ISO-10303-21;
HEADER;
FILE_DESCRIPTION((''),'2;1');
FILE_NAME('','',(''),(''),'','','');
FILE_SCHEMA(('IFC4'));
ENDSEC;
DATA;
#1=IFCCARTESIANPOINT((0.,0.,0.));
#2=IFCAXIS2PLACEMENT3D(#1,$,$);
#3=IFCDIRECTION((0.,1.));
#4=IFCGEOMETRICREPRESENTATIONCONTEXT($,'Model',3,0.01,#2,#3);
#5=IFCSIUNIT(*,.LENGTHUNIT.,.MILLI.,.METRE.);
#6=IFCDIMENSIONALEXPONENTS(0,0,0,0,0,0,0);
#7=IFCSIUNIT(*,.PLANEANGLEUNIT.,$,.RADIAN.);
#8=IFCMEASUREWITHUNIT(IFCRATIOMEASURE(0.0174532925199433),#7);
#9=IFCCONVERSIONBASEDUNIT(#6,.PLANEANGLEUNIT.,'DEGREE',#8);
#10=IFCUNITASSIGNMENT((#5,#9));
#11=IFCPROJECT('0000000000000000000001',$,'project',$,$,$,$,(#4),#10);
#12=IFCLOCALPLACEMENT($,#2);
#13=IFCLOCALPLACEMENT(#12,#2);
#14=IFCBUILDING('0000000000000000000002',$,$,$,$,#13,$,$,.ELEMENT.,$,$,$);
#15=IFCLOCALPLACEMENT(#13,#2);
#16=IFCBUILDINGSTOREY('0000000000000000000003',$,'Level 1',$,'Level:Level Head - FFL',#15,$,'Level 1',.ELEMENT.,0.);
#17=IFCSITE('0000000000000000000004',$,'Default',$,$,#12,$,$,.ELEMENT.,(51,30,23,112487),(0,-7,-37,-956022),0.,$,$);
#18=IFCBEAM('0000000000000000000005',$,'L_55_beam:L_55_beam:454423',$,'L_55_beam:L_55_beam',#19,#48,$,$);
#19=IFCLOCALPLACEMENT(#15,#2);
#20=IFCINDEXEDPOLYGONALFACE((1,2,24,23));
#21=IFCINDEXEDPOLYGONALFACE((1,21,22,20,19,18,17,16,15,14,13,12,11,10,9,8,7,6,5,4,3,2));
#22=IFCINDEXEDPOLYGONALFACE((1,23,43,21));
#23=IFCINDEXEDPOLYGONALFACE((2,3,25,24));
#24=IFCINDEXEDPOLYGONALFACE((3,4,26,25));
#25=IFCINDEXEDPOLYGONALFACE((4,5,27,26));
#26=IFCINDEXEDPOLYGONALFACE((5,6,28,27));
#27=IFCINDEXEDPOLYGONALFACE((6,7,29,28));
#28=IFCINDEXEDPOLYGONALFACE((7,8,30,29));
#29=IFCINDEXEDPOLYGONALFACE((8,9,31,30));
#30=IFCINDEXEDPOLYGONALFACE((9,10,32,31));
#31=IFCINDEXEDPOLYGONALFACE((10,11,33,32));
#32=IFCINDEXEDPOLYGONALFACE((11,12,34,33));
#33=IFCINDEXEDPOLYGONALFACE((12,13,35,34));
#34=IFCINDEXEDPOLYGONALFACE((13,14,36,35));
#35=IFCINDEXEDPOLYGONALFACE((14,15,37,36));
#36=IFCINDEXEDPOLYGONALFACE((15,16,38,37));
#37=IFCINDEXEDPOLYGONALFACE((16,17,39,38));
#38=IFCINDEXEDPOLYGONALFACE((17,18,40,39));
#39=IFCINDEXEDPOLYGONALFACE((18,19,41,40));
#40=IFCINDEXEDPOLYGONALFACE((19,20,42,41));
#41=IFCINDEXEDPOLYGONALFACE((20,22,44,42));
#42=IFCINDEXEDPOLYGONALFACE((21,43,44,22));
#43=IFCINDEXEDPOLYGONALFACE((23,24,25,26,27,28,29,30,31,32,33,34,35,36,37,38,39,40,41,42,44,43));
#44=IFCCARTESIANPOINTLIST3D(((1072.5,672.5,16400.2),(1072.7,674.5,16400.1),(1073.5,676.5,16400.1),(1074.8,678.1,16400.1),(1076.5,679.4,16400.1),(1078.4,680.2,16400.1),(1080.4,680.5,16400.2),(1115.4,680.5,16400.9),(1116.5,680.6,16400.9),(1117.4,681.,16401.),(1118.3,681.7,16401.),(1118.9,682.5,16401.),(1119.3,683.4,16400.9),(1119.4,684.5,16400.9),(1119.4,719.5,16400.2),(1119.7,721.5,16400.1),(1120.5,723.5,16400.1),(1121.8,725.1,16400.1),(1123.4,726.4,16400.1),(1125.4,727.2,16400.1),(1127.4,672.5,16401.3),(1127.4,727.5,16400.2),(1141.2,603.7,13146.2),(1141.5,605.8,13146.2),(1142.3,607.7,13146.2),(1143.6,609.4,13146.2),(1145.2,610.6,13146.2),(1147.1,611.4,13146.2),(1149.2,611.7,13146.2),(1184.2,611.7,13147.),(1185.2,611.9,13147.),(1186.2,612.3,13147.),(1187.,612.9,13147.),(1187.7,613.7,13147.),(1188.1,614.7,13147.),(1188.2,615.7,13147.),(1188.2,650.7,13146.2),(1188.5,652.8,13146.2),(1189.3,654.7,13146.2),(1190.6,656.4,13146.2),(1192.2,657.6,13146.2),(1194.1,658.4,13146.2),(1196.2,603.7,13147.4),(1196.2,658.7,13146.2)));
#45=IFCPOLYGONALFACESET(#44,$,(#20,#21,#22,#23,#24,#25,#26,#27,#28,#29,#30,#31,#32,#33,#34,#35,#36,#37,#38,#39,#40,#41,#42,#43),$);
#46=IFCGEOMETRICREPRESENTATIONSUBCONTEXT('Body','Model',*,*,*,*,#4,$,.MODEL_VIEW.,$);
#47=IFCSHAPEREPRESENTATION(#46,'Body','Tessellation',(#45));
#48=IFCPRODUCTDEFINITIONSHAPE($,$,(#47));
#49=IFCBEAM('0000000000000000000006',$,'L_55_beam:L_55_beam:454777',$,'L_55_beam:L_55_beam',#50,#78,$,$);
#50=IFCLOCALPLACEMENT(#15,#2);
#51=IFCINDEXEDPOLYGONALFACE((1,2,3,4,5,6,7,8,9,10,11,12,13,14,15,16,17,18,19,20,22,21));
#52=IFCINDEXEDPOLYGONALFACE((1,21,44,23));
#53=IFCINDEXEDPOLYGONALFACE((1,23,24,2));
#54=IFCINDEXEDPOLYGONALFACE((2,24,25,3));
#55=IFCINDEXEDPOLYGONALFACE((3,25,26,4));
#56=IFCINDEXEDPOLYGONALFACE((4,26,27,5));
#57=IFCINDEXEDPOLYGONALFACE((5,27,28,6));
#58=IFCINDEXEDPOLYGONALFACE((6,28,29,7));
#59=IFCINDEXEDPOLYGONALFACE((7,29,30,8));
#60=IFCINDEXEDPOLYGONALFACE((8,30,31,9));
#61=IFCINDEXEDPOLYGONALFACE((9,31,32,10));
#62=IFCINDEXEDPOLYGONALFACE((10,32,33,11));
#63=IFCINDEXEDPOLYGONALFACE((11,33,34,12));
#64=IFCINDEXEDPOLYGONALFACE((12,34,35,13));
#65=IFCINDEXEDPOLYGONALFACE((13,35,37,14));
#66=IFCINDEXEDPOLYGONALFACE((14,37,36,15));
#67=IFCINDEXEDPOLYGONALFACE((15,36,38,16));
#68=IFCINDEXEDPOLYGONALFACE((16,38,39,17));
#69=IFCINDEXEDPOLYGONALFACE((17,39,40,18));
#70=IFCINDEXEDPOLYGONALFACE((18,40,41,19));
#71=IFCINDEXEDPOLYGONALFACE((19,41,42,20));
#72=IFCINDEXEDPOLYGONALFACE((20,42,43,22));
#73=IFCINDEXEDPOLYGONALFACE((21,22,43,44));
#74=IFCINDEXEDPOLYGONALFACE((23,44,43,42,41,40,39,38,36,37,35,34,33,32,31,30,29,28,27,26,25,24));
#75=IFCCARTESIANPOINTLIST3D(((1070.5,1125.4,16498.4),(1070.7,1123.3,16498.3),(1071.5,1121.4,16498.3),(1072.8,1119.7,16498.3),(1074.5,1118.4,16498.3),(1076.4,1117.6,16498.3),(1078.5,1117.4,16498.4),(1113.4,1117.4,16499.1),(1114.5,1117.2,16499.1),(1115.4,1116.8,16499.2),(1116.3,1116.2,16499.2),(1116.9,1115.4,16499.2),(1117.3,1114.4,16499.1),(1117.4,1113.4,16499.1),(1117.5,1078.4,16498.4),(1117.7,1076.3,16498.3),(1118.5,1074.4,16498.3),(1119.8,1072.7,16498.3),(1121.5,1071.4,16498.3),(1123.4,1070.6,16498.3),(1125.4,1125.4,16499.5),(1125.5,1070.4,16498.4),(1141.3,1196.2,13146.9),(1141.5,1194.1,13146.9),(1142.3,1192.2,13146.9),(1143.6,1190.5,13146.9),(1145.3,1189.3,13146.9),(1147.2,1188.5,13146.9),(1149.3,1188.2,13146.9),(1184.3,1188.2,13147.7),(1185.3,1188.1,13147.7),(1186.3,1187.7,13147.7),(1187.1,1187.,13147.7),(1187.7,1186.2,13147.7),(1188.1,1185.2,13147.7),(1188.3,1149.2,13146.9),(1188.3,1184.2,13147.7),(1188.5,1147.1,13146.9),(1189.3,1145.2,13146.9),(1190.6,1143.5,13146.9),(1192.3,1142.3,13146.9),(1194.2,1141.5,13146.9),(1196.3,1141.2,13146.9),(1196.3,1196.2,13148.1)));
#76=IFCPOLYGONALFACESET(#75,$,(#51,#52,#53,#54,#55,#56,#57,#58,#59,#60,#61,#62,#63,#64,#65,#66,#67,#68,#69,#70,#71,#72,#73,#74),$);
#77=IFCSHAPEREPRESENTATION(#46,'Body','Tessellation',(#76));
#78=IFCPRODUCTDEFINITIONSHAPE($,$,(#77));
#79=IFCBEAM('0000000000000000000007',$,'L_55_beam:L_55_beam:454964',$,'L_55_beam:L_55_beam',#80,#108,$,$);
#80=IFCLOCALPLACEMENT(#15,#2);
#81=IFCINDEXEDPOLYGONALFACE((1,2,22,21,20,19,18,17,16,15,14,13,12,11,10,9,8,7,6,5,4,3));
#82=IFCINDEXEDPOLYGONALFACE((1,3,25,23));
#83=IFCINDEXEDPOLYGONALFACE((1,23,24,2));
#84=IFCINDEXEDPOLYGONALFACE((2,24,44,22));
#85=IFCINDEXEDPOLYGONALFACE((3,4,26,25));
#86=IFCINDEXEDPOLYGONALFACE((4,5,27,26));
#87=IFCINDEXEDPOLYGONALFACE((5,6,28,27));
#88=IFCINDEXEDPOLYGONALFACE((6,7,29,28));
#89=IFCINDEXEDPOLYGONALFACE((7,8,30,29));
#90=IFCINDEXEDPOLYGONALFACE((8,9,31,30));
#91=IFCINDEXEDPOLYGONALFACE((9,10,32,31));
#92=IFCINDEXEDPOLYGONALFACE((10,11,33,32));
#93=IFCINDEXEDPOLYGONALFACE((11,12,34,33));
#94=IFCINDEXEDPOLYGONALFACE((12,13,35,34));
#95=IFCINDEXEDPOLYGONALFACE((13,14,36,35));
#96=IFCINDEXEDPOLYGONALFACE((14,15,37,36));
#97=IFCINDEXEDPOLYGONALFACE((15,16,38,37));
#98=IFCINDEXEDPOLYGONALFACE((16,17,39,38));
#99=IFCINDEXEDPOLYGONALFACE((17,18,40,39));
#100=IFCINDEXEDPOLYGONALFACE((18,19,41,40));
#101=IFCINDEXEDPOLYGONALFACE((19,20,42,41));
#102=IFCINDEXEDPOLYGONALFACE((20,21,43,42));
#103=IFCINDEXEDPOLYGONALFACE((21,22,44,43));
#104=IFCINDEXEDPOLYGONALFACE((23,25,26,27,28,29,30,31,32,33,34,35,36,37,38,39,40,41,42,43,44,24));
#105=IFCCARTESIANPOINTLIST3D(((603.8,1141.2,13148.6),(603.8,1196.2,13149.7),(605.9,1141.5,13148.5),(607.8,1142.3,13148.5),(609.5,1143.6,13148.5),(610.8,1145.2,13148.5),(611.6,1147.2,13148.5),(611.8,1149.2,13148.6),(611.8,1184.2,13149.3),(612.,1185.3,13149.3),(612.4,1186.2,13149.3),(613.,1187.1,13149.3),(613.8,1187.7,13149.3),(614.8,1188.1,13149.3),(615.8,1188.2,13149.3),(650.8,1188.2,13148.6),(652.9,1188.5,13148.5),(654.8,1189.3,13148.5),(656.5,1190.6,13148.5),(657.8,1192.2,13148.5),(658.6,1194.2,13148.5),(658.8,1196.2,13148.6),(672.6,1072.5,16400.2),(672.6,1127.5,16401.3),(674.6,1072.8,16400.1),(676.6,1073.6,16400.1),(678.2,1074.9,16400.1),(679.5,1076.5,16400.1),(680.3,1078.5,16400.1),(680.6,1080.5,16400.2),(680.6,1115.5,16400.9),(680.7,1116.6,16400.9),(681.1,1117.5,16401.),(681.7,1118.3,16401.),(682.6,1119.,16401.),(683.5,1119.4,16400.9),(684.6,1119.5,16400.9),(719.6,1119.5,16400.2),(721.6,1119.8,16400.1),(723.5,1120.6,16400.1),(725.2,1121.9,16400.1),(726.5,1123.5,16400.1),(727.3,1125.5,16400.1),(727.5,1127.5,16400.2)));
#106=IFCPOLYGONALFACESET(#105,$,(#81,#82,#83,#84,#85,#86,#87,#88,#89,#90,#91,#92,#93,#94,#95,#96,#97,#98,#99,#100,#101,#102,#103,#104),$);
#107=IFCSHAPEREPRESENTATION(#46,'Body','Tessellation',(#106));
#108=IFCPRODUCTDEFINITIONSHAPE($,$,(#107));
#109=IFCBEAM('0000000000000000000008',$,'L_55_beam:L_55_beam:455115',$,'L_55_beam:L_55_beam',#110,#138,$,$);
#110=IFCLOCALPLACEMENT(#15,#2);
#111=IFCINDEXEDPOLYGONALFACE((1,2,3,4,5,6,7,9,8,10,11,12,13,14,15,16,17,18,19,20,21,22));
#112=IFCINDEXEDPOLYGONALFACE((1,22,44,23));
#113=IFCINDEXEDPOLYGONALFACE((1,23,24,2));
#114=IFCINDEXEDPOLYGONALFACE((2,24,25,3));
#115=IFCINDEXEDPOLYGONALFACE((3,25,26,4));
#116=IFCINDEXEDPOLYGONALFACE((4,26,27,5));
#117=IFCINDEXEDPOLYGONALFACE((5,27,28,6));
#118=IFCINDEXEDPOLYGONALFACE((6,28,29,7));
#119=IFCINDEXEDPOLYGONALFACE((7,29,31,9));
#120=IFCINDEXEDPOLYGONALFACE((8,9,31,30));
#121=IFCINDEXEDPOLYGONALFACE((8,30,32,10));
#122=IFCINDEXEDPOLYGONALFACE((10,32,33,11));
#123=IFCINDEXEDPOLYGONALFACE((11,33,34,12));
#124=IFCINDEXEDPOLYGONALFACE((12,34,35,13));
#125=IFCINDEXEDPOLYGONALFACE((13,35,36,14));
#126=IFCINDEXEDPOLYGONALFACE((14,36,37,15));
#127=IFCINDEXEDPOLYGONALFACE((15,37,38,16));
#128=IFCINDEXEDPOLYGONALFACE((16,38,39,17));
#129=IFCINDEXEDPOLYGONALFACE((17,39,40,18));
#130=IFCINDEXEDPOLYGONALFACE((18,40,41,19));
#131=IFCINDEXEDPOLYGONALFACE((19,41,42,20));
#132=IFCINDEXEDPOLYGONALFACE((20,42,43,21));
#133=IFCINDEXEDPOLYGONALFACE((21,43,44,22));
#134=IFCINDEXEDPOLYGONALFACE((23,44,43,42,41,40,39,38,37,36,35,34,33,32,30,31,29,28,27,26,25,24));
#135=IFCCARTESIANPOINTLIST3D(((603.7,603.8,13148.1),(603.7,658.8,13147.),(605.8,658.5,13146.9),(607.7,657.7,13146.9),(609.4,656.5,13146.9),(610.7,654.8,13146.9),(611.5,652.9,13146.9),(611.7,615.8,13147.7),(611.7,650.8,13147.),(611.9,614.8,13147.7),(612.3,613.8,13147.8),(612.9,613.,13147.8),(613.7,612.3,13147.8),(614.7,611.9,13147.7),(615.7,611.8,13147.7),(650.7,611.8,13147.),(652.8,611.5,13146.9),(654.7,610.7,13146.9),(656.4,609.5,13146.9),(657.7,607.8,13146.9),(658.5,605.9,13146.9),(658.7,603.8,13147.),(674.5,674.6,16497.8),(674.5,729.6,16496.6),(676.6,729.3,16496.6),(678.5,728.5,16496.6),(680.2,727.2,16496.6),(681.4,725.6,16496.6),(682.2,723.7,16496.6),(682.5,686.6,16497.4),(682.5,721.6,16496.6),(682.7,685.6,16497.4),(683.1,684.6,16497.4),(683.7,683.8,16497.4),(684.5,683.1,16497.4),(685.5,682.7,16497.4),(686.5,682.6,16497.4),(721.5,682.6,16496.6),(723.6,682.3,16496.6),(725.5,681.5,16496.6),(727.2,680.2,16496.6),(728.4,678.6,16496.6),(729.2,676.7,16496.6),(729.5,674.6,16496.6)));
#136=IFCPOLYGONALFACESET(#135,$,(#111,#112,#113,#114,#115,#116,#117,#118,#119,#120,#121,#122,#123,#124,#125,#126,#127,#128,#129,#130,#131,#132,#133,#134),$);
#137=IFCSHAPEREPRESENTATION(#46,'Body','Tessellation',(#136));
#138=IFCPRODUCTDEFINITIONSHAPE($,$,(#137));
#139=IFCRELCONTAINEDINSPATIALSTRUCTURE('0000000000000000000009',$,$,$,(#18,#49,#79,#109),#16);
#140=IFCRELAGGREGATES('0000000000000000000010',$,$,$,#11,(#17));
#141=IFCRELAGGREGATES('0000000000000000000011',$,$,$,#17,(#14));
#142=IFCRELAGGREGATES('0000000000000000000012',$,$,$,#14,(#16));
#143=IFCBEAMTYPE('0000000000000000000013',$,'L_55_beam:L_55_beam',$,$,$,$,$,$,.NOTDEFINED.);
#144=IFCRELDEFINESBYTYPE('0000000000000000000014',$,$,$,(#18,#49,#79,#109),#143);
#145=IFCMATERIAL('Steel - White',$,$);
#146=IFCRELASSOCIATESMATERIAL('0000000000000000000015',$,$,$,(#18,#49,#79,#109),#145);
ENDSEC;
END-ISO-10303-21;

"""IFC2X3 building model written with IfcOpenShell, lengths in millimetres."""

from ifc_helpers import new_model, entity, si_unit, converted_unit, direction, frame, frame_2d, origin, place, context, subcontext, project, spatial, polyline, circle_curve, parameter, trimmed, segment, composite_curve, outline, extrude, material, type_object, element, save


model = new_model("IFC2X3")

# Units and contexts
model_context = context("Model", 3, precision=0.01, world=origin(), true_north=direction((0.0, 1.0)))
body_context = subcontext(model_context, "Body", "Model", "MODEL_VIEW")
ifc_project = project(units=[si_unit("LENGTHUNIT", "METRE", prefix="MILLI"), converted_unit("PLANEANGLEUNIT", "DEGREE", entity("IfcRatioMeasure", 0.0174532925199433), si_unit("PLANEANGLEUNIT", "RADIAN"), dimensions=[0, 0, 0, 0, 0, 0, 0])], contexts=[model_context])

# Site, building, storey
site_placement = place(None, origin())
site = spatial("IfcSite", under=ifc_project, at=site_placement, Name="Default", CompositionType="ELEMENT", RefLatitude=(51, 30, 23, 112487), RefLongitude=(0, -7, -37, -956022), RefElevation=0.0)
building_placement = place(site_placement, origin())
building = spatial("IfcBuilding", under=site, at=building_placement, CompositionType="ELEMENT")
storey_placement = place(building_placement, origin())
storey = spatial("IfcBuildingStorey", under=building, at=storey_placement, Name="Level 1", ObjectType="Level:Level Head - FFL", LongName="Level 1", CompositionType="ELEMENT", Elevation=0.0)

# Beams
beam_type_1 = type_object("IfcBeamType", Name="L_55_beam:L_55_beam", PredefinedType="NOTDEFINED")
ifc_material_1 = material(Name="Steel - White")
beam_1_placement = place(storey_placement, frame((1125.2, 674.7, 16505.7), z_axis=(0.999777, 0.000446, 0.02112), x_axis=(0.021125, -0.02112, -0.999554)))
element("IfcBeam", 1, at=beam_1_placement, inside=storey, type_object=beam_type_1, material=ifc_material_1, Name="L_55_beam:L_55_beam:454423", ObjectType="L_55_beam:L_55_beam", context=body_context, shape_type="SweptSolid", body=[
    extrude(outline(composite_curve([segment(polyline([(-36.4, -18.6), (18.6, -18.6)]), True, "CONTINUOUS"), segment(polyline([(18.6, -18.6), (18.6, 36.4)]), True, "CONTINUOUS"), segment(trimmed(circle_curve(frame_2d((18.6, 28.4), x_axis=(0.0, 1.0)), 8.0), [parameter(0.0)], [parameter(90.0)], True, "PARAMETER"), True, "CONTINUOUS"), segment(polyline([(10.6, 28.4), (10.6, -6.6)]), True, "CONTINUOUS"), segment(trimmed(circle_curve(frame_2d((6.6, -6.6), x_axis=(1.0, 0.0)), 4.0), [parameter(270.0)], [parameter(0.0)], True, "PARAMETER"), False, "CONTINUOUS"), segment(polyline([(6.6, -10.6), (-28.4, -10.6)]), True, "CONTINUOUS"), segment(trimmed(circle_curve(frame_2d((-28.4, -18.6), x_axis=(0.0, 1.0)), 8.0), [parameter(0.0)], [parameter(90.0)], True, "PARAMETER"), True, "CONTINUOUS")], self_intersect=False)), frame((104.4, 18.6, -18.6), z_axis=(1.0, 0.0, 0.0), x_axis=(0.0, -1.0, -0.000112)), (0.0, 0.0, 1.0), 3255.4),
])
beam_2_placement = place(storey_placement, frame((1125.4, 1125.4, 16499.5), z_axis=(0.999777, -0.000446, 0.021115), x_axis=(0.02112, 0.021125, -0.999554)))
element("IfcBeam", 2, at=beam_2_placement, inside=storey, type_object=beam_type_1, material=ifc_material_1, Name="L_55_beam:L_55_beam:454777", ObjectType="L_55_beam:L_55_beam", context=body_context, shape_type="SweptSolid", body=[
    extrude(outline(composite_curve([segment(polyline([(-36.4, -18.6), (18.6, -18.6)]), True, "CONTINUOUS"), segment(polyline([(18.6, -18.6), (18.6, 36.4)]), True, "CONTINUOUS"), segment(trimmed(circle_curve(frame_2d((18.6, 28.4), x_axis=(0.0, 1.0)), 8.0), [parameter(0.0)], [parameter(90.0)], True, "PARAMETER"), True, "CONTINUOUS"), segment(polyline([(10.6, 28.4), (10.6, -6.6)]), True, "CONTINUOUS"), segment(trimmed(circle_curve(frame_2d((6.6, -6.6), x_axis=(1.0, 0.0)), 4.0), [parameter(270.0)], [parameter(0.0)], True, "PARAMETER"), False, "CONTINUOUS"), segment(polyline([(6.6, -10.6), (-28.4, -10.6)]), True, "CONTINUOUS"), segment(trimmed(circle_curve(frame_2d((-28.4, -18.6), x_axis=(0.0, 1.0)), 8.0), [parameter(0.0)], [parameter(90.0)], True, "PARAMETER"), True, "CONTINUOUS")], self_intersect=False)), frame((0.0, -18.6, -18.6), z_axis=(1.0, 0.0, 0.0), x_axis=(0.0, 0.000332, 1.0)), (0.0, 0.0, 1.0), 3353.0),
])
beam_3_placement = place(storey_placement, frame((674.6, 1125.4, 16499.7), z_axis=(0.999777, 0.000446, -0.02112), x_axis=(-0.021125, 0.02112, -0.999554)))
element("IfcBeam", 3, at=beam_3_placement, inside=storey, type_object=beam_type_1, material=ifc_material_1, Name="L_55_beam:L_55_beam:454964", ObjectType="L_55_beam:L_55_beam", context=body_context, shape_type="SweptSolid", body=[
    extrude(outline(composite_curve([segment(polyline([(-18.6, -18.6), (36.4, -18.6)]), True, "CONTINUOUS"), segment(trimmed(circle_curve(frame_2d((28.4, -18.6), x_axis=(1.0, 0.0)), 8.0), [parameter(0.0)], [parameter(90.0)], True, "PARAMETER"), True, "CONTINUOUS"), segment(polyline([(28.4, -10.6), (-6.6, -10.6)]), True, "CONTINUOUS"), segment(trimmed(circle_curve(frame_2d((-6.6, -6.6), x_axis=(0.0, -1.0)), 4.0), [parameter(270.0)], [parameter(0.0)], True, "PARAMETER"), False, "CONTINUOUS"), segment(polyline([(-10.6, -6.6), (-10.6, 28.4)]), True, "CONTINUOUS"), segment(trimmed(circle_curve(frame_2d((-18.6, 28.4), x_axis=(1.0, 0.0)), 8.0), [parameter(0.0)], [parameter(90.0)], True, "PARAMETER"), True, "CONTINUOUS"), segment(polyline([(-18.6, 36.4), (-18.6, -18.6)]), True, "CONTINUOUS")], self_intersect=False)), frame((98.4, -18.6, 18.6), z_axis=(1.0, 0.0, 0.0), x_axis=(0.0, -0.000112, 1.0)), (0.0, 0.0, 1.0), 3253.1),
])
beam_4_placement = place(storey_placement, frame((674.5, 674.6, 16497.8), z_axis=(0.999777, -0.000446, -0.021115), x_axis=(-0.02112, -0.021125, -0.999554)))
element("IfcBeam", 4, at=beam_4_placement, inside=storey, type_object=beam_type_1, material=ifc_material_1, Name="L_55_beam:L_55_beam:455115", ObjectType="L_55_beam:L_55_beam", context=body_context, shape_type="SweptSolid", body=[
    extrude(outline(composite_curve([segment(polyline([(-6.6, 10.6), (28.4, 10.6)]), True, "CONTINUOUS"), segment(trimmed(circle_curve(frame_2d((28.4, 18.6), x_axis=(0.0, -1.0)), 8.0), [parameter(0.0)], [parameter(90.0)], True, "PARAMETER"), True, "CONTINUOUS"), segment(polyline([(36.4, 18.6), (-18.6, 18.6)]), True, "CONTINUOUS"), segment(polyline([(-18.6, 18.6), (-18.6, -36.4)]), True, "CONTINUOUS"), segment(trimmed(circle_curve(frame_2d((-18.6, -28.4), x_axis=(0.0, -1.0)), 8.0), [parameter(0.0)], [parameter(90.0)], True, "PARAMETER"), True, "CONTINUOUS"), segment(polyline([(-10.6, -28.4), (-10.6, 6.6)]), True, "CONTINUOUS"), segment(trimmed(circle_curve(frame_2d((-6.6, 6.6), x_axis=(-1.0, 0.0)), 4.0), [parameter(270.0)], [parameter(0.0)], True, "PARAMETER"), False, "CONTINUOUS")], self_intersect=False)), frame((0.0, 18.6, 18.6), z_axis=(1.0, 0.0, 0.0), x_axis=(0.0, 0.000332, 1.0)), (0.0, 0.0, 1.0), 3351.1),
])

save(model, "model.ifc")
